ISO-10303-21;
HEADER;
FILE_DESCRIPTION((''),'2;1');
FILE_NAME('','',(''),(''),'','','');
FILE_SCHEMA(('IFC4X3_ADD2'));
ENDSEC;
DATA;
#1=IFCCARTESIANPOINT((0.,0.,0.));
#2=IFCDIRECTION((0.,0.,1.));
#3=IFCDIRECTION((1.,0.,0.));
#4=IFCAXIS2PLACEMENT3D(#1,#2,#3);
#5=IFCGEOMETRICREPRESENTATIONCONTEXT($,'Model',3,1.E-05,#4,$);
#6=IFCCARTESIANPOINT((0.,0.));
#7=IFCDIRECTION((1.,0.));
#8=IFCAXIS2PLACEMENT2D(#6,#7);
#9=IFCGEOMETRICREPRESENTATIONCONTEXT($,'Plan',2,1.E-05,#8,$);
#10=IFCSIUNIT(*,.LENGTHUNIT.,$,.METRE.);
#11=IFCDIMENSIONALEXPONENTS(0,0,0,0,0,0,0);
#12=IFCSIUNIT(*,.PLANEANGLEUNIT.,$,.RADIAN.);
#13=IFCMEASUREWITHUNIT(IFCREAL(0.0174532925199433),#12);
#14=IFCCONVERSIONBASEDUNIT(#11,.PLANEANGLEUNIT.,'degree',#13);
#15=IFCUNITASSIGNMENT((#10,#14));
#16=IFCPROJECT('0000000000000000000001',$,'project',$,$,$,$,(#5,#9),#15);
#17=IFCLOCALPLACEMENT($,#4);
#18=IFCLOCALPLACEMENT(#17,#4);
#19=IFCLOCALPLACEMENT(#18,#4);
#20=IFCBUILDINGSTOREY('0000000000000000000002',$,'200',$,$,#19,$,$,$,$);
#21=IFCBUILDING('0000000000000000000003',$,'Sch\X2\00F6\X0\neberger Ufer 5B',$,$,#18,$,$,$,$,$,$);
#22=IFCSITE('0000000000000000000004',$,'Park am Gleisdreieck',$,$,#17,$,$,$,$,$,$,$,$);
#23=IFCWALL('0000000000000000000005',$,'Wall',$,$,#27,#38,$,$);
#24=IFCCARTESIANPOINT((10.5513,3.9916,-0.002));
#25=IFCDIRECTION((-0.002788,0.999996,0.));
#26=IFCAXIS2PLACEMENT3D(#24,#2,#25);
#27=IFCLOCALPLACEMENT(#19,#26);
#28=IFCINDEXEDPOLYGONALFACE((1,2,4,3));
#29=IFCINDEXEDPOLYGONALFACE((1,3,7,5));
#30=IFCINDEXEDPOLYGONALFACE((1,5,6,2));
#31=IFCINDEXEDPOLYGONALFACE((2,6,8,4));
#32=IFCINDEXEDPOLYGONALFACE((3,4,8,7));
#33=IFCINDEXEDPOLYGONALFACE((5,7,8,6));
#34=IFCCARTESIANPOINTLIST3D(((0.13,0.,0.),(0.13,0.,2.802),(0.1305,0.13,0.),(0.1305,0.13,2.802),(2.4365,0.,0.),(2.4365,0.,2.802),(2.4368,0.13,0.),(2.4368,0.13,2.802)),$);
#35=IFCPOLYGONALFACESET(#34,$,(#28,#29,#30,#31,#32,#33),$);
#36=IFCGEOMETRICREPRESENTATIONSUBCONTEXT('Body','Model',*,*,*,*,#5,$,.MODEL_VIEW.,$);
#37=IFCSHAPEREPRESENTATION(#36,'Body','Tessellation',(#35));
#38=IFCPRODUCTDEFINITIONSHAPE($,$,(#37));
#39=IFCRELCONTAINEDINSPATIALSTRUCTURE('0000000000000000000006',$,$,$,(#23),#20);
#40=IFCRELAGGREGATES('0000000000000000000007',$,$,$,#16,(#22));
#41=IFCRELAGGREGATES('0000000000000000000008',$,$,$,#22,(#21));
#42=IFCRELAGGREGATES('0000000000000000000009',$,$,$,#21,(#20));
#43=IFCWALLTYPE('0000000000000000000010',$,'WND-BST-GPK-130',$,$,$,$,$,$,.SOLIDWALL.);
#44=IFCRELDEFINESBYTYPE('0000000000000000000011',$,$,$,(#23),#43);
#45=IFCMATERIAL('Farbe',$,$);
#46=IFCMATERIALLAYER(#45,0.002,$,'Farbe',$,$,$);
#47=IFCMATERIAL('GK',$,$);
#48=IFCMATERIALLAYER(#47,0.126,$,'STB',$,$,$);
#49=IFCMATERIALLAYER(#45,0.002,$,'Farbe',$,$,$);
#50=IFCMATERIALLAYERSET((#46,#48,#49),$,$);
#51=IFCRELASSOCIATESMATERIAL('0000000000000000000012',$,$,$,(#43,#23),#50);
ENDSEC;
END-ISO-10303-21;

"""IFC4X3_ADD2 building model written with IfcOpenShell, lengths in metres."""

from ifc_helpers import new_model, entity, si_unit, converted_unit, frame, origin_with_axes, origin_2d_with_axis, place, context, subcontext, project, spatial, line, indexed_curve, outline, extrude, material, layer, layer_set, layer_usage, type_object, element, save


model = new_model("IFC4X3_ADD2")

# Units and contexts
model_context = context("Model", 3, precision=1e-05, world=origin_with_axes())
plan_context = context("Plan", 2, precision=1e-05, world=origin_2d_with_axis())
body_context = subcontext(model_context, "Body", "Model", "MODEL_VIEW")
ifc_project = project(units=[si_unit("LENGTHUNIT", "METRE"), converted_unit("PLANEANGLEUNIT", "degree", entity("IfcReal", 0.0174532925199433), si_unit("PLANEANGLEUNIT", "RADIAN"), dimensions=[0, 0, 0, 0, 0, 0, 0])], contexts=[model_context, plan_context])

# Site, building, storey
site_placement = place(None, origin_with_axes())
site = spatial("IfcSite", under=ifc_project, at=site_placement, Name="Park am Gleisdreieck")
building_placement = place(site_placement, origin_with_axes())
building = spatial("IfcBuilding", under=site, at=building_placement, Name="Schöneberger Ufer 5B")
storey_placement = place(building_placement, origin_with_axes())
storey = spatial("IfcBuildingStorey", under=building, at=storey_placement, Name="200")

# Wall
ifc_material_1 = material(Name="Farbe")
ifc_layer_1 = layer(ifc_material_1, 0.002, Name="Farbe")
ifc_material_2 = material(Name="GK")
ifc_layer_2 = layer(ifc_material_2, 0.126, Name="STB")
ifc_layer_3 = layer(ifc_material_1, 0.002, Name="Farbe")
ifc_layer_set_1 = layer_set([ifc_layer_1, ifc_layer_2, ifc_layer_3])
wall_type_1 = type_object("IfcWallType", Name="WND-BST-GPK-130", PredefinedType="SOLIDWALL", material=ifc_layer_set_1)
ifc_layer_usage_1 = layer_usage(ifc_layer_set_1, "AXIS2", "POSITIVE", 0.0)
wall_1_placement = place(storey_placement, frame((10.5513, 3.9916, -0.002), z_axis=(0.0, 0.0, 1.0), x_axis=(-0.002788, 0.999996, 0.0)))
element("IfcWall", 1, at=wall_1_placement, inside=storey, type_object=wall_type_1, material=ifc_layer_usage_1, Name="Wall", context=body_context, shape_type="SweptSolid", body=[
    extrude(outline(indexed_curve([(0.13, 0.0), (0.1305, 0.13), (2.4368, 0.13), (2.4365, 0.0)], segments=[line(1, 2, 3, 4, 1)])), origin_with_axes(), (0.0, 0.0, 1.0), 2.802),
])

save(model, "model.ifc")
